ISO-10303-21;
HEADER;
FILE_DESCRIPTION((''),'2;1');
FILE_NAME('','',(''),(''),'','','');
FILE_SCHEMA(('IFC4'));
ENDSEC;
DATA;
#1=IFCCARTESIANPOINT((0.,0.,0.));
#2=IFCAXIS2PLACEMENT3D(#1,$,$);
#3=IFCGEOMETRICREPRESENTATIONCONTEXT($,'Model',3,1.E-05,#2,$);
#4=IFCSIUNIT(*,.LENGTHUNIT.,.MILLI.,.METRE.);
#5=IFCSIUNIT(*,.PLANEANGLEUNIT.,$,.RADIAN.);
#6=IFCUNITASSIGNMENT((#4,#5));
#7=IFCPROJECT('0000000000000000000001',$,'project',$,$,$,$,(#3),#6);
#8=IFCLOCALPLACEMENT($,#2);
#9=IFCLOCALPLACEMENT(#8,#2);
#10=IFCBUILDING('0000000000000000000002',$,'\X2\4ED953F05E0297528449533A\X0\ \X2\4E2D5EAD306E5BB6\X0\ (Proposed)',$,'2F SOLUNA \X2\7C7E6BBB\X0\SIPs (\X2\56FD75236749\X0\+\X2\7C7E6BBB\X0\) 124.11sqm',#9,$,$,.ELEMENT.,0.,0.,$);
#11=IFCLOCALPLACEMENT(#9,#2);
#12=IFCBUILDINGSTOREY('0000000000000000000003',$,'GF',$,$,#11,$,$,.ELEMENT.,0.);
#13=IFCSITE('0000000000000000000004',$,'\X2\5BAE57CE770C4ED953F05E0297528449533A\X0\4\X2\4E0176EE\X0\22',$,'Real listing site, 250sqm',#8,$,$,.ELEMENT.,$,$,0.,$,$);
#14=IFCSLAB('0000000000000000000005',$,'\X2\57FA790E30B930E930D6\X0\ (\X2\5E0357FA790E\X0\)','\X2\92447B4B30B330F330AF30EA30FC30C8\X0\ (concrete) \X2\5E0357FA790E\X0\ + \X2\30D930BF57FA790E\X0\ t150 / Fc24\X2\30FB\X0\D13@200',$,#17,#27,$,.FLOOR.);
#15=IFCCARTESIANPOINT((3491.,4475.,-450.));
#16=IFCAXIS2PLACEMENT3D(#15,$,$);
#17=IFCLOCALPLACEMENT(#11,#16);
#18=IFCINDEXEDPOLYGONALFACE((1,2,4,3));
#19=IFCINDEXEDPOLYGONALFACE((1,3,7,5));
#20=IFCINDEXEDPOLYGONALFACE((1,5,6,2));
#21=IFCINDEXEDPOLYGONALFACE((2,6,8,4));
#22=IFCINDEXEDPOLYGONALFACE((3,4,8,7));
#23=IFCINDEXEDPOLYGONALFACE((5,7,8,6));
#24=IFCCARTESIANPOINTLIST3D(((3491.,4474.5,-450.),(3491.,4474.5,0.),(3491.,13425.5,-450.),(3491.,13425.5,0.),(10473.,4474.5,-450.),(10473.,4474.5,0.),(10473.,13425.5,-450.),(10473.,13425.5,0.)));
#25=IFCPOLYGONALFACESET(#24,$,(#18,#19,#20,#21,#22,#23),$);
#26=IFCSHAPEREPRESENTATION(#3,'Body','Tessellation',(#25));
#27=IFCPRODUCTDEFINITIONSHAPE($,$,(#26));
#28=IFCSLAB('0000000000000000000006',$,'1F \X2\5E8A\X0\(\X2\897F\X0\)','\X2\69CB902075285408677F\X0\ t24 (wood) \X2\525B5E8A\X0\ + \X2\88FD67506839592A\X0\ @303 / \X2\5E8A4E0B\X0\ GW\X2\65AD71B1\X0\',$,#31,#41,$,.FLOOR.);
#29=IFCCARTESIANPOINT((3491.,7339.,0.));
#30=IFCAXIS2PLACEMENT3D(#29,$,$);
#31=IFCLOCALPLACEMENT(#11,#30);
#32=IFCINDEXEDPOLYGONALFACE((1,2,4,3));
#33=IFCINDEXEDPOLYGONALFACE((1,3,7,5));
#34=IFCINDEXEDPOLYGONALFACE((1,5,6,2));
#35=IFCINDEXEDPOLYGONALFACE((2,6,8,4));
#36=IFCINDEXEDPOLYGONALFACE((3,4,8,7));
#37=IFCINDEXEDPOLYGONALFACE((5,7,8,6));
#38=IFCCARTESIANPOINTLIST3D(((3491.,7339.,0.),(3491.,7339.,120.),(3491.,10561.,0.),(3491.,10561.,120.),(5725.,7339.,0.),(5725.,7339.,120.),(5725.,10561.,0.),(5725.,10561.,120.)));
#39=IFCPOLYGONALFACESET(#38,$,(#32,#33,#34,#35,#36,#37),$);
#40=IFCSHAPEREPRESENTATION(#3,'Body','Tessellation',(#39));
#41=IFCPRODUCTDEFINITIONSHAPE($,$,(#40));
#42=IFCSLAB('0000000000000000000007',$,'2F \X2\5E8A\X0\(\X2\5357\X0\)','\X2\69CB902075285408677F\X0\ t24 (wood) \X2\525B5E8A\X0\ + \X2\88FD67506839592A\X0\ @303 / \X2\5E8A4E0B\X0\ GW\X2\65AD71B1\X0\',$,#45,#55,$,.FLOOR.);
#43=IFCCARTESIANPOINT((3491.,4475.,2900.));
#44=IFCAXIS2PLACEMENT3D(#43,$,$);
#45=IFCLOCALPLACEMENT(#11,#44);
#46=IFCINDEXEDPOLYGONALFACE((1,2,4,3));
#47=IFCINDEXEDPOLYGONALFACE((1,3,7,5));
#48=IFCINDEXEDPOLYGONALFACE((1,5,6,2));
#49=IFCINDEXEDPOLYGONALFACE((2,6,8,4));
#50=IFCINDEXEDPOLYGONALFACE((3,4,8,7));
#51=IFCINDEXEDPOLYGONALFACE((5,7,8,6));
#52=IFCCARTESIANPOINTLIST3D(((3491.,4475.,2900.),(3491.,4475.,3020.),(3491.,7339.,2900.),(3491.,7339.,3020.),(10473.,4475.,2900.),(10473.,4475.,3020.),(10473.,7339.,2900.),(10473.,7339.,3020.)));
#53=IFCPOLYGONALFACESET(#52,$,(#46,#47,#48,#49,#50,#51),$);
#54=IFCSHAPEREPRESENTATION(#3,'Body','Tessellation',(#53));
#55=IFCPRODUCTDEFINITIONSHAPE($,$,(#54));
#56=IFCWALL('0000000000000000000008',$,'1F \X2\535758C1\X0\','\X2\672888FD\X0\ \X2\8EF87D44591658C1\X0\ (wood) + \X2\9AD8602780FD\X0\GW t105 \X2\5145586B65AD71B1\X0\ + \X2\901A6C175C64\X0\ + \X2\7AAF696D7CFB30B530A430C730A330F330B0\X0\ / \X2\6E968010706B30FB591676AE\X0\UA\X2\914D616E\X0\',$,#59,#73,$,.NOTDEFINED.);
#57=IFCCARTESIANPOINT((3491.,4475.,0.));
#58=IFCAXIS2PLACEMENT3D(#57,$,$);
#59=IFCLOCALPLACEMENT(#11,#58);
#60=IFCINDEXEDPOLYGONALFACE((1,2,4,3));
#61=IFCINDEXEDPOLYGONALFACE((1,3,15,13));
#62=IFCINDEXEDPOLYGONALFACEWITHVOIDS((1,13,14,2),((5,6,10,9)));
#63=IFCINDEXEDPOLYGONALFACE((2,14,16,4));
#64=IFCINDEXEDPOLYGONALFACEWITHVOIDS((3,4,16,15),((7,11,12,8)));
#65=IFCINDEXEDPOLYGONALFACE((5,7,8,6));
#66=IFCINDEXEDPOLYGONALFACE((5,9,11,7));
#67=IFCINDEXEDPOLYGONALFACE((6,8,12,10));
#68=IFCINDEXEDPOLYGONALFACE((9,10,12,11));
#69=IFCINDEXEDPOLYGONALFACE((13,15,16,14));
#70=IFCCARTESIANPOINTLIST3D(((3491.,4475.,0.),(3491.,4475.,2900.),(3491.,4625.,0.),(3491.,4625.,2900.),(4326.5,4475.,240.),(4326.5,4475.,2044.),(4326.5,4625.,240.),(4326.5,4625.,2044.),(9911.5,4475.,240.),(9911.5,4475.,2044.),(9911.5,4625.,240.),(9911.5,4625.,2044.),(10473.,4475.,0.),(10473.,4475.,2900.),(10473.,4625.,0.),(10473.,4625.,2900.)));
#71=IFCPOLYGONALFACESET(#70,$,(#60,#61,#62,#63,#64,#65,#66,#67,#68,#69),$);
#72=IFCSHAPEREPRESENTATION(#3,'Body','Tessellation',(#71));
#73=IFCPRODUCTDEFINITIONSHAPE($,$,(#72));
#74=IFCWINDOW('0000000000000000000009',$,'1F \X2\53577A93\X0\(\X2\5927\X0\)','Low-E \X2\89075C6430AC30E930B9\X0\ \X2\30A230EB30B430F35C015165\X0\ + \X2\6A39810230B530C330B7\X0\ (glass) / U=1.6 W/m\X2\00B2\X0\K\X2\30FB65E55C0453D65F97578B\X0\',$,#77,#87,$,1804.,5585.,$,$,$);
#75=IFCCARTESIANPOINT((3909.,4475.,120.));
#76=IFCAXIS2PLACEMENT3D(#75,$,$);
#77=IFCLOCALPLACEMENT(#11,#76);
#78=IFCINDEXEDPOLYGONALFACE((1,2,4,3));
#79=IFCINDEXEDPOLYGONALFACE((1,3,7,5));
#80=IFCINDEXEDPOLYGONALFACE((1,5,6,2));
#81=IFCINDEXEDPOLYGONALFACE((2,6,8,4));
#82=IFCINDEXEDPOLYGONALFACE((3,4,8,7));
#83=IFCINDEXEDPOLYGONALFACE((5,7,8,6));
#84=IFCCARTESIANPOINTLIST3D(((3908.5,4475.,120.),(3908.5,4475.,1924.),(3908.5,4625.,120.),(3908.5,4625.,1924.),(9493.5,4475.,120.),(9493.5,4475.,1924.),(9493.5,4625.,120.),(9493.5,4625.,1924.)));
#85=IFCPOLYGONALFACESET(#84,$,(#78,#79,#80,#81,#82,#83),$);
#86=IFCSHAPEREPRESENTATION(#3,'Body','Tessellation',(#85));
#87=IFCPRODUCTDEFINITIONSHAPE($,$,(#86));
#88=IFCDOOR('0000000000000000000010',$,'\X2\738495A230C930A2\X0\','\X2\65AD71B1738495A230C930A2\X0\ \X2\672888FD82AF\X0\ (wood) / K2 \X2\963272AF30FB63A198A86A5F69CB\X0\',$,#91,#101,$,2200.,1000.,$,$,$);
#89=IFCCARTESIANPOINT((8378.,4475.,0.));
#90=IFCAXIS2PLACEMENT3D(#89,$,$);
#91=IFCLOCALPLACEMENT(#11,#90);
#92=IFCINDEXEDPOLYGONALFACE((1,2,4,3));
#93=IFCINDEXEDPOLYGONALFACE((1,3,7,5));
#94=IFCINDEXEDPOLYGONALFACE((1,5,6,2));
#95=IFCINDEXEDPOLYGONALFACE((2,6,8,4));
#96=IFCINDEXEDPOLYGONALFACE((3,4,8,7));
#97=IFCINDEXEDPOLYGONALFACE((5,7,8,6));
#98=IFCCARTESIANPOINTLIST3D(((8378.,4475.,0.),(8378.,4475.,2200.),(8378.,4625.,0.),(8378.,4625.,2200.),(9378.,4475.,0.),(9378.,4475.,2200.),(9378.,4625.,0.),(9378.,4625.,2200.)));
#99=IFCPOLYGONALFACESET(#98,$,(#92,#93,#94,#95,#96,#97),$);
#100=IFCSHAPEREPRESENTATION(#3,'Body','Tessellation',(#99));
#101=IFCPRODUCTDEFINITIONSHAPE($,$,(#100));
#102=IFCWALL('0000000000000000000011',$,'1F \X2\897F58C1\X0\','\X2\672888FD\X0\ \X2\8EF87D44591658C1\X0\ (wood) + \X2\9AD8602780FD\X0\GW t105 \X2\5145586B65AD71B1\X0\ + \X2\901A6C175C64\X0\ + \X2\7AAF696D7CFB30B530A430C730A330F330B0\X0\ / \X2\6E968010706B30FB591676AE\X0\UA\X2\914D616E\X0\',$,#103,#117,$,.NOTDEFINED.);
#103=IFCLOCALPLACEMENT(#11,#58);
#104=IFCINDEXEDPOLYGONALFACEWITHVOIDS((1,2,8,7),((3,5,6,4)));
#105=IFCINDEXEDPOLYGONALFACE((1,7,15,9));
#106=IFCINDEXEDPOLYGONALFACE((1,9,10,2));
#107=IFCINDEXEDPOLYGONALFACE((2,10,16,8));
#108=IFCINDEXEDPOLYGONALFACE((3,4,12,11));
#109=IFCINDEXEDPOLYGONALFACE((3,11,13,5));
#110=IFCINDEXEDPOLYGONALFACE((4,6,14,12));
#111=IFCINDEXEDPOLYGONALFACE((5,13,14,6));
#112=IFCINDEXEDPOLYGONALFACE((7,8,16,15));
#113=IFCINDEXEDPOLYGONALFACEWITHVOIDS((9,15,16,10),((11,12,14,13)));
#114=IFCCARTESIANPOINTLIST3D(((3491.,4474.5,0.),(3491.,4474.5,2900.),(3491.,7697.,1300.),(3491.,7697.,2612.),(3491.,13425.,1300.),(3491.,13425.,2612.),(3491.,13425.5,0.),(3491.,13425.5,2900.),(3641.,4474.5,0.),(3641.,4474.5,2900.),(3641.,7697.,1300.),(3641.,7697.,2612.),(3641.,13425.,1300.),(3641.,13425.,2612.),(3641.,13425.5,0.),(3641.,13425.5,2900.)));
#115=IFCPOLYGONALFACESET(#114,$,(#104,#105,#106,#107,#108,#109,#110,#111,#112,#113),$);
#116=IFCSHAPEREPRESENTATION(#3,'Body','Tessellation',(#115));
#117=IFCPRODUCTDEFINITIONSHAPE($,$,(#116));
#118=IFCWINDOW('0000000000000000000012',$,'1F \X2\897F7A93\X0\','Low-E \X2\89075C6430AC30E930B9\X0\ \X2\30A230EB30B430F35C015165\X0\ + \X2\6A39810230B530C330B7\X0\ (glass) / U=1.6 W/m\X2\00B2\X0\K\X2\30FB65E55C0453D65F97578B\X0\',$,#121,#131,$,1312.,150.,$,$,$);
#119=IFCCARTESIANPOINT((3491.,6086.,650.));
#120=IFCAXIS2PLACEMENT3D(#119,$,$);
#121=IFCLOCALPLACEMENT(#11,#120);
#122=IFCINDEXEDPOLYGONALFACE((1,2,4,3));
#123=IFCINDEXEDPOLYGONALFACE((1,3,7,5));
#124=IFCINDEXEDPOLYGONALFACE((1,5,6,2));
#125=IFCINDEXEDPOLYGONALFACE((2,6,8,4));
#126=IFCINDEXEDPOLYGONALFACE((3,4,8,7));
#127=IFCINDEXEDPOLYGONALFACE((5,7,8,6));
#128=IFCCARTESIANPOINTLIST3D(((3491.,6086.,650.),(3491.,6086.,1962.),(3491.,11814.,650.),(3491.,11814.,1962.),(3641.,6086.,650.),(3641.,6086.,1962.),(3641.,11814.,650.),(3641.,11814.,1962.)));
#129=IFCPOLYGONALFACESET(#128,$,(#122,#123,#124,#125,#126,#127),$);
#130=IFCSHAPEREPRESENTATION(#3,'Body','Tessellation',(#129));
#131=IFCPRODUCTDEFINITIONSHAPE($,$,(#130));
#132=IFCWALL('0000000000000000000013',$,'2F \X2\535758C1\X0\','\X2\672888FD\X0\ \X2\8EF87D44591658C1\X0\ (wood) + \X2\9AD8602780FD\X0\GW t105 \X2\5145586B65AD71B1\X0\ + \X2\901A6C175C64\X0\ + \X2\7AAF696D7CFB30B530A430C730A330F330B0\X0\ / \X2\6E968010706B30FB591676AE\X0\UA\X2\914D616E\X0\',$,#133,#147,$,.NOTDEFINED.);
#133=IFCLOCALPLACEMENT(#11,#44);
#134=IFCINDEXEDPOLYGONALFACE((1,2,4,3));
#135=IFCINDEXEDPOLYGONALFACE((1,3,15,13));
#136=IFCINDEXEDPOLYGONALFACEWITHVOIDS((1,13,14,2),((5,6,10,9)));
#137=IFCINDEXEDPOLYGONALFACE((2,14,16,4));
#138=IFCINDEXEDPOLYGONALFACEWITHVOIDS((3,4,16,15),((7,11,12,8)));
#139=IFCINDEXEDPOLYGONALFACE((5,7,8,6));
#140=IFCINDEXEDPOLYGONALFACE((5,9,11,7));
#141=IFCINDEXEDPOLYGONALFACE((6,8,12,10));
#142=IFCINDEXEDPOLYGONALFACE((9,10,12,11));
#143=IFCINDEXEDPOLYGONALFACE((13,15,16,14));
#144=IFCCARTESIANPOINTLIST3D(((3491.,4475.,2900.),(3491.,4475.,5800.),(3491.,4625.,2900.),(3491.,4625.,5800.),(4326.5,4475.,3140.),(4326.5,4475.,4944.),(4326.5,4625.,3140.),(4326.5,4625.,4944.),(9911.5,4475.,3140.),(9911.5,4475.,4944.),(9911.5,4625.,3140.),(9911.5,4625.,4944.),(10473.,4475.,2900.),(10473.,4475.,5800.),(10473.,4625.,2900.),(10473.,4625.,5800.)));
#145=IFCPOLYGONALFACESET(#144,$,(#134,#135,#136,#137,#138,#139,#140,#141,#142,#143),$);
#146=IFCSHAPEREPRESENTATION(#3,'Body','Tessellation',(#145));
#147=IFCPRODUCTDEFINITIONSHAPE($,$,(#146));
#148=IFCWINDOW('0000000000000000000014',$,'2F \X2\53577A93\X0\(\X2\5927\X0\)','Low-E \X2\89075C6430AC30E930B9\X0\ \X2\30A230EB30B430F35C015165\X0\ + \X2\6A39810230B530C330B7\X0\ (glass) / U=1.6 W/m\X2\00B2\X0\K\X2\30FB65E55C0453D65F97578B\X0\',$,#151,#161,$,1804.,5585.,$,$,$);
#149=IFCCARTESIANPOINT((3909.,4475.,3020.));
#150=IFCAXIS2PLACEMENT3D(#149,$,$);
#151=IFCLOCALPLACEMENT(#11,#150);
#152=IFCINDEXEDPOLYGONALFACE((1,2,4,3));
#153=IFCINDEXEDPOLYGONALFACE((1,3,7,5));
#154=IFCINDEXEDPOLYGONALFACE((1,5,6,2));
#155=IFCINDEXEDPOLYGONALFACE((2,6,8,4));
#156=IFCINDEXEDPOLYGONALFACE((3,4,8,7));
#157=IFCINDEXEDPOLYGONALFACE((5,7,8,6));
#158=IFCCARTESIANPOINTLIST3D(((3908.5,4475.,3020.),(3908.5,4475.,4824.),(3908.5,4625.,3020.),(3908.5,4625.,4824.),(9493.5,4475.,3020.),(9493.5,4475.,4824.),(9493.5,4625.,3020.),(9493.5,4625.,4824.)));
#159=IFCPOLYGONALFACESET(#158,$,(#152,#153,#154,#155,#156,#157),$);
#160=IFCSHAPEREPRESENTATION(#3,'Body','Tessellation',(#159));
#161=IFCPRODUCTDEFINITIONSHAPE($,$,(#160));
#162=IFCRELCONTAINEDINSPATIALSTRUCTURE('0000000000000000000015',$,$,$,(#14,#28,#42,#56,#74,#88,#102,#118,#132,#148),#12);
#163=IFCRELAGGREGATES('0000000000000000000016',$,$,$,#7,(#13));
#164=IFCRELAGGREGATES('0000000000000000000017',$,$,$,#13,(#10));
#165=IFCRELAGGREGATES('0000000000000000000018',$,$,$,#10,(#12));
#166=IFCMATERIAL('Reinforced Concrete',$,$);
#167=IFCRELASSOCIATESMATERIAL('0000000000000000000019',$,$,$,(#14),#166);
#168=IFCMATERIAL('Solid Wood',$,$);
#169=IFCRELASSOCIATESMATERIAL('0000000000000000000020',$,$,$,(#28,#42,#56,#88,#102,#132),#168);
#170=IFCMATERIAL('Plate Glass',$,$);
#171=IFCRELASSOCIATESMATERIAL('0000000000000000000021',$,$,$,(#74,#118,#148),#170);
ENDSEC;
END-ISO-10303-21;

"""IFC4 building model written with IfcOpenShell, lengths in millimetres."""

from ifc_helpers import new_model, si_unit, frame, frame_2d, origin, place, context, project, spatial, rectangle, extrude, material, element, fill, save


model = new_model("IFC4")

# Units and contexts
model_context = context("Model", 3, precision=1e-05, world=origin())
ifc_project = project(units=[si_unit("LENGTHUNIT", "METRE", prefix="MILLI"), si_unit("PLANEANGLEUNIT", "RADIAN")], contexts=[model_context])

# Site, building, storey
site_placement = place(None, origin())
site = spatial("IfcSite", under=ifc_project, at=site_placement, Name="宮城県仙台市青葉区4丁目22", ObjectType="Real listing site, 250sqm", CompositionType="ELEMENT", RefElevation=0.0)
building_placement = place(site_placement, origin())
building = spatial("IfcBuilding", under=site, at=building_placement, Name="仙台市青葉区 中庭の家 (Proposed)", ObjectType="2F SOLUNA 籾殻SIPs (国産杉+籾殻) 124.11sqm", CompositionType="ELEMENT", ElevationOfRefHeight=0.0, ElevationOfTerrain=0.0)
storey_placement = place(building_placement, origin())
storey = spatial("IfcBuildingStorey", under=building, at=storey_placement, Name="GF", CompositionType="ELEMENT", Elevation=0.0)

# Slabs
ifc_material_1 = material(Name="Reinforced Concrete")
slab_1_placement = place(storey_placement, frame((3491.0, 4475.0, -450.0)))
element("IfcSlab", 1, at=slab_1_placement, inside=storey, material=ifc_material_1, Name="基礎スラブ (布基礎)", Description="鉄筋コンクリート (concrete) 布基礎 + ベタ基礎 t150 / Fc24・D13@200", PredefinedType="FLOOR", context=model_context, shape_type="SweptSolid", body=[
    extrude(rectangle(XDim=6982.0, YDim=8951.0, at=frame_2d((3491.0, 4475.0))), frame((3491.0, 4475.0, -450.0)), (0.0, 0.0, 1.0), 450.0),
])
ifc_material_2 = material(Name="Solid Wood")
slab_2_placement = place(storey_placement, frame((3491.0, 7339.0, 0.0)))
element("IfcSlab", 2, at=slab_2_placement, inside=storey, material=ifc_material_2, Name="1F 床(西)", Description="構造用合板 t24 (wood) 剛床 + 製材根太 @303 / 床下 GW断熱", PredefinedType="FLOOR", context=model_context, shape_type="SweptSolid", body=[
    extrude(rectangle(XDim=2234.0, YDim=3222.0, at=frame_2d((1117.0, 1611.0))), frame((3491.0, 7339.0, 0.0)), (0.0, 0.0, 1.0), 120.0),
])
slab_3_placement = place(storey_placement, frame((3491.0, 4475.0, 2900.0)))
element("IfcSlab", 3, at=slab_3_placement, inside=storey, material=ifc_material_2, Name="2F 床(南)", Description="構造用合板 t24 (wood) 剛床 + 製材根太 @303 / 床下 GW断熱", PredefinedType="FLOOR", context=model_context, shape_type="SweptSolid", body=[
    extrude(rectangle(XDim=6982.0, YDim=2864.0, at=frame_2d((3491.0, 1432.0))), frame((3491.0, 4475.0, 2900.0)), (0.0, 0.0, 1.0), 120.0),
])

# Wall, openings, window, door
wall_1_placement = place(storey_placement, frame((3491.0, 4475.0, 0.0)))
wall_1 = element("IfcWall", 4, at=wall_1_placement, inside=storey, material=ifc_material_2, Name="1F 南壁", Description="木製 軸組外壁 (wood) + 高性能GW t105 充填断熱 + 通気層 + 窯業系サイディング / 準耐火・外皮UA配慮", PredefinedType="NOTDEFINED", context=model_context, shape_type="SweptSolid", body=[
    extrude(rectangle(XDim=6982.0, YDim=150.0, at=frame_2d((3491.0, 75.0))), frame((3491.0, 4475.0, 0.0)), (0.0, 0.0, 1.0), 2900.0),
])
opening_1_placement = place(storey_placement, frame((3909.0, 4475.0, 120.0)))
opening_1 = element("IfcOpeningElement", 5, at=opening_1_placement, cuts=wall_1, PredefinedType="NOTDEFINED", context=model_context, shape_type="SweptSolid", body=[
    extrude(rectangle(XDim=5585.0, YDim=150.0, at=frame_2d((2792.0, 75.0))), frame((3909.0, 4475.0, 120.0)), (0.0, 0.0, 1.0), 1804.0),
])
opening_2_placement = place(storey_placement, frame((8378.0, 4475.0, 0.0)))
opening_2 = element("IfcOpeningElement", 6, at=opening_2_placement, cuts=wall_1, PredefinedType="NOTDEFINED", context=model_context, shape_type="SweptSolid", body=[
    extrude(rectangle(XDim=1000.0, YDim=150.0, at=frame_2d((500.0, 75.0))), frame((8378.0, 4475.0, 0.0)), (0.0, 0.0, 1.0), 2200.0),
])
ifc_material_3 = material(Name="Plate Glass")
window_1_placement = place(storey_placement, frame((3909.0, 4475.0, 120.0)))
window_1 = element("IfcWindow", 7, at=window_1_placement, inside=storey, material=ifc_material_3, Name="1F 南窓(大)", Description="Low-E 複層ガラス アルゴン封入 + 樹脂サッシ (glass) / U=1.6 W/m²K・日射取得型", OverallHeight=1804.0, OverallWidth=5585.0, context=model_context, shape_type="SweptSolid", body=[
    extrude(rectangle(XDim=5585.0, YDim=150.0, at=frame_2d((2792.0, 75.0))), frame((3909.0, 4475.0, 120.0)), (0.0, 0.0, 1.0), 1804.0),
])
fill(opening_1, window_1)
door_placement = place(storey_placement, frame((8378.0, 4475.0, 0.0)))
door = element("IfcDoor", 8, at=door_placement, inside=storey, material=ifc_material_2, Name="玄関ドア", Description="断熱玄関ドア 木製芯 (wood) / K2 防犯・採風機構", OverallHeight=2200.0, OverallWidth=1000.0, context=model_context, shape_type="SweptSolid", body=[
    extrude(rectangle(XDim=1000.0, YDim=150.0, at=frame_2d((500.0, 75.0))), frame((8378.0, 4475.0, 0.0)), (0.0, 0.0, 1.0), 2200.0),
])
fill(opening_2, door)

# Walls, openings, windows
wall_2_placement = place(storey_placement, frame((3491.0, 4475.0, 0.0)))
wall_2 = element("IfcWall", 9, at=wall_2_placement, inside=storey, material=ifc_material_2, Name="1F 西壁", Description="木製 軸組外壁 (wood) + 高性能GW t105 充填断熱 + 通気層 + 窯業系サイディング / 準耐火・外皮UA配慮", PredefinedType="NOTDEFINED", context=model_context, shape_type="SweptSolid", body=[
    extrude(rectangle(XDim=150.0, YDim=8951.0, at=frame_2d((75.0, 4475.0))), frame((3491.0, 4475.0, 0.0)), (0.0, 0.0, 1.0), 2900.0),
])
opening_3_placement = place(storey_placement, frame((3491.0, 6086.0, 650.0)))
opening_3 = element("IfcOpeningElement", 10, at=opening_3_placement, cuts=wall_2, PredefinedType="NOTDEFINED", context=model_context, shape_type="SweptSolid", body=[
    extrude(rectangle(XDim=150.0, YDim=5728.0, at=frame_2d((75.0, 2864.0))), frame((3491.0, 6086.0, 650.0)), (0.0, 0.0, 1.0), 1312.0),
])
window_2_placement = place(storey_placement, frame((3491.0, 6086.0, 650.0)))
window_2 = element("IfcWindow", 11, at=window_2_placement, inside=storey, material=ifc_material_3, Name="1F 西窓", Description="Low-E 複層ガラス アルゴン封入 + 樹脂サッシ (glass) / U=1.6 W/m²K・日射取得型", OverallHeight=1312.0, OverallWidth=150.0, context=model_context, shape_type="SweptSolid", body=[
    extrude(rectangle(XDim=150.0, YDim=5728.0, at=frame_2d((75.0, 2864.0))), frame((3491.0, 6086.0, 650.0)), (0.0, 0.0, 1.0), 1312.0),
])
fill(opening_3, window_2)
wall_3_placement = place(storey_placement, frame((3491.0, 4475.0, 2900.0)))
wall_3 = element("IfcWall", 12, at=wall_3_placement, inside=storey, material=ifc_material_2, Name="2F 南壁", Description="木製 軸組外壁 (wood) + 高性能GW t105 充填断熱 + 通気層 + 窯業系サイディング / 準耐火・外皮UA配慮", PredefinedType="NOTDEFINED", context=model_context, shape_type="SweptSolid", body=[
    extrude(rectangle(XDim=6982.0, YDim=150.0, at=frame_2d((3491.0, 75.0))), frame((3491.0, 4475.0, 2900.0)), (0.0, 0.0, 1.0), 2900.0),
])
opening_4_placement = place(storey_placement, frame((3909.0, 4475.0, 3020.0)))
opening_4 = element("IfcOpeningElement", 13, at=opening_4_placement, cuts=wall_3, PredefinedType="NOTDEFINED", context=model_context, shape_type="SweptSolid", body=[
    extrude(rectangle(XDim=5585.0, YDim=150.0, at=frame_2d((2792.0, 75.0))), frame((3909.0, 4475.0, 3020.0)), (0.0, 0.0, 1.0), 1804.0),
])
window_3_placement = place(storey_placement, frame((3909.0, 4475.0, 3020.0)))
window_3 = element("IfcWindow", 14, at=window_3_placement, inside=storey, material=ifc_material_3, Name="2F 南窓(大)", Description="Low-E 複層ガラス アルゴン封入 + 樹脂サッシ (glass) / U=1.6 W/m²K・日射取得型", OverallHeight=1804.0, OverallWidth=5585.0, context=model_context, shape_type="SweptSolid", body=[
    extrude(rectangle(XDim=5585.0, YDim=150.0, at=frame_2d((2792.0, 75.0))), frame((3909.0, 4475.0, 3020.0)), (0.0, 0.0, 1.0), 1804.0),
])
fill(opening_4, window_3)

save(model, "model.ifc")
